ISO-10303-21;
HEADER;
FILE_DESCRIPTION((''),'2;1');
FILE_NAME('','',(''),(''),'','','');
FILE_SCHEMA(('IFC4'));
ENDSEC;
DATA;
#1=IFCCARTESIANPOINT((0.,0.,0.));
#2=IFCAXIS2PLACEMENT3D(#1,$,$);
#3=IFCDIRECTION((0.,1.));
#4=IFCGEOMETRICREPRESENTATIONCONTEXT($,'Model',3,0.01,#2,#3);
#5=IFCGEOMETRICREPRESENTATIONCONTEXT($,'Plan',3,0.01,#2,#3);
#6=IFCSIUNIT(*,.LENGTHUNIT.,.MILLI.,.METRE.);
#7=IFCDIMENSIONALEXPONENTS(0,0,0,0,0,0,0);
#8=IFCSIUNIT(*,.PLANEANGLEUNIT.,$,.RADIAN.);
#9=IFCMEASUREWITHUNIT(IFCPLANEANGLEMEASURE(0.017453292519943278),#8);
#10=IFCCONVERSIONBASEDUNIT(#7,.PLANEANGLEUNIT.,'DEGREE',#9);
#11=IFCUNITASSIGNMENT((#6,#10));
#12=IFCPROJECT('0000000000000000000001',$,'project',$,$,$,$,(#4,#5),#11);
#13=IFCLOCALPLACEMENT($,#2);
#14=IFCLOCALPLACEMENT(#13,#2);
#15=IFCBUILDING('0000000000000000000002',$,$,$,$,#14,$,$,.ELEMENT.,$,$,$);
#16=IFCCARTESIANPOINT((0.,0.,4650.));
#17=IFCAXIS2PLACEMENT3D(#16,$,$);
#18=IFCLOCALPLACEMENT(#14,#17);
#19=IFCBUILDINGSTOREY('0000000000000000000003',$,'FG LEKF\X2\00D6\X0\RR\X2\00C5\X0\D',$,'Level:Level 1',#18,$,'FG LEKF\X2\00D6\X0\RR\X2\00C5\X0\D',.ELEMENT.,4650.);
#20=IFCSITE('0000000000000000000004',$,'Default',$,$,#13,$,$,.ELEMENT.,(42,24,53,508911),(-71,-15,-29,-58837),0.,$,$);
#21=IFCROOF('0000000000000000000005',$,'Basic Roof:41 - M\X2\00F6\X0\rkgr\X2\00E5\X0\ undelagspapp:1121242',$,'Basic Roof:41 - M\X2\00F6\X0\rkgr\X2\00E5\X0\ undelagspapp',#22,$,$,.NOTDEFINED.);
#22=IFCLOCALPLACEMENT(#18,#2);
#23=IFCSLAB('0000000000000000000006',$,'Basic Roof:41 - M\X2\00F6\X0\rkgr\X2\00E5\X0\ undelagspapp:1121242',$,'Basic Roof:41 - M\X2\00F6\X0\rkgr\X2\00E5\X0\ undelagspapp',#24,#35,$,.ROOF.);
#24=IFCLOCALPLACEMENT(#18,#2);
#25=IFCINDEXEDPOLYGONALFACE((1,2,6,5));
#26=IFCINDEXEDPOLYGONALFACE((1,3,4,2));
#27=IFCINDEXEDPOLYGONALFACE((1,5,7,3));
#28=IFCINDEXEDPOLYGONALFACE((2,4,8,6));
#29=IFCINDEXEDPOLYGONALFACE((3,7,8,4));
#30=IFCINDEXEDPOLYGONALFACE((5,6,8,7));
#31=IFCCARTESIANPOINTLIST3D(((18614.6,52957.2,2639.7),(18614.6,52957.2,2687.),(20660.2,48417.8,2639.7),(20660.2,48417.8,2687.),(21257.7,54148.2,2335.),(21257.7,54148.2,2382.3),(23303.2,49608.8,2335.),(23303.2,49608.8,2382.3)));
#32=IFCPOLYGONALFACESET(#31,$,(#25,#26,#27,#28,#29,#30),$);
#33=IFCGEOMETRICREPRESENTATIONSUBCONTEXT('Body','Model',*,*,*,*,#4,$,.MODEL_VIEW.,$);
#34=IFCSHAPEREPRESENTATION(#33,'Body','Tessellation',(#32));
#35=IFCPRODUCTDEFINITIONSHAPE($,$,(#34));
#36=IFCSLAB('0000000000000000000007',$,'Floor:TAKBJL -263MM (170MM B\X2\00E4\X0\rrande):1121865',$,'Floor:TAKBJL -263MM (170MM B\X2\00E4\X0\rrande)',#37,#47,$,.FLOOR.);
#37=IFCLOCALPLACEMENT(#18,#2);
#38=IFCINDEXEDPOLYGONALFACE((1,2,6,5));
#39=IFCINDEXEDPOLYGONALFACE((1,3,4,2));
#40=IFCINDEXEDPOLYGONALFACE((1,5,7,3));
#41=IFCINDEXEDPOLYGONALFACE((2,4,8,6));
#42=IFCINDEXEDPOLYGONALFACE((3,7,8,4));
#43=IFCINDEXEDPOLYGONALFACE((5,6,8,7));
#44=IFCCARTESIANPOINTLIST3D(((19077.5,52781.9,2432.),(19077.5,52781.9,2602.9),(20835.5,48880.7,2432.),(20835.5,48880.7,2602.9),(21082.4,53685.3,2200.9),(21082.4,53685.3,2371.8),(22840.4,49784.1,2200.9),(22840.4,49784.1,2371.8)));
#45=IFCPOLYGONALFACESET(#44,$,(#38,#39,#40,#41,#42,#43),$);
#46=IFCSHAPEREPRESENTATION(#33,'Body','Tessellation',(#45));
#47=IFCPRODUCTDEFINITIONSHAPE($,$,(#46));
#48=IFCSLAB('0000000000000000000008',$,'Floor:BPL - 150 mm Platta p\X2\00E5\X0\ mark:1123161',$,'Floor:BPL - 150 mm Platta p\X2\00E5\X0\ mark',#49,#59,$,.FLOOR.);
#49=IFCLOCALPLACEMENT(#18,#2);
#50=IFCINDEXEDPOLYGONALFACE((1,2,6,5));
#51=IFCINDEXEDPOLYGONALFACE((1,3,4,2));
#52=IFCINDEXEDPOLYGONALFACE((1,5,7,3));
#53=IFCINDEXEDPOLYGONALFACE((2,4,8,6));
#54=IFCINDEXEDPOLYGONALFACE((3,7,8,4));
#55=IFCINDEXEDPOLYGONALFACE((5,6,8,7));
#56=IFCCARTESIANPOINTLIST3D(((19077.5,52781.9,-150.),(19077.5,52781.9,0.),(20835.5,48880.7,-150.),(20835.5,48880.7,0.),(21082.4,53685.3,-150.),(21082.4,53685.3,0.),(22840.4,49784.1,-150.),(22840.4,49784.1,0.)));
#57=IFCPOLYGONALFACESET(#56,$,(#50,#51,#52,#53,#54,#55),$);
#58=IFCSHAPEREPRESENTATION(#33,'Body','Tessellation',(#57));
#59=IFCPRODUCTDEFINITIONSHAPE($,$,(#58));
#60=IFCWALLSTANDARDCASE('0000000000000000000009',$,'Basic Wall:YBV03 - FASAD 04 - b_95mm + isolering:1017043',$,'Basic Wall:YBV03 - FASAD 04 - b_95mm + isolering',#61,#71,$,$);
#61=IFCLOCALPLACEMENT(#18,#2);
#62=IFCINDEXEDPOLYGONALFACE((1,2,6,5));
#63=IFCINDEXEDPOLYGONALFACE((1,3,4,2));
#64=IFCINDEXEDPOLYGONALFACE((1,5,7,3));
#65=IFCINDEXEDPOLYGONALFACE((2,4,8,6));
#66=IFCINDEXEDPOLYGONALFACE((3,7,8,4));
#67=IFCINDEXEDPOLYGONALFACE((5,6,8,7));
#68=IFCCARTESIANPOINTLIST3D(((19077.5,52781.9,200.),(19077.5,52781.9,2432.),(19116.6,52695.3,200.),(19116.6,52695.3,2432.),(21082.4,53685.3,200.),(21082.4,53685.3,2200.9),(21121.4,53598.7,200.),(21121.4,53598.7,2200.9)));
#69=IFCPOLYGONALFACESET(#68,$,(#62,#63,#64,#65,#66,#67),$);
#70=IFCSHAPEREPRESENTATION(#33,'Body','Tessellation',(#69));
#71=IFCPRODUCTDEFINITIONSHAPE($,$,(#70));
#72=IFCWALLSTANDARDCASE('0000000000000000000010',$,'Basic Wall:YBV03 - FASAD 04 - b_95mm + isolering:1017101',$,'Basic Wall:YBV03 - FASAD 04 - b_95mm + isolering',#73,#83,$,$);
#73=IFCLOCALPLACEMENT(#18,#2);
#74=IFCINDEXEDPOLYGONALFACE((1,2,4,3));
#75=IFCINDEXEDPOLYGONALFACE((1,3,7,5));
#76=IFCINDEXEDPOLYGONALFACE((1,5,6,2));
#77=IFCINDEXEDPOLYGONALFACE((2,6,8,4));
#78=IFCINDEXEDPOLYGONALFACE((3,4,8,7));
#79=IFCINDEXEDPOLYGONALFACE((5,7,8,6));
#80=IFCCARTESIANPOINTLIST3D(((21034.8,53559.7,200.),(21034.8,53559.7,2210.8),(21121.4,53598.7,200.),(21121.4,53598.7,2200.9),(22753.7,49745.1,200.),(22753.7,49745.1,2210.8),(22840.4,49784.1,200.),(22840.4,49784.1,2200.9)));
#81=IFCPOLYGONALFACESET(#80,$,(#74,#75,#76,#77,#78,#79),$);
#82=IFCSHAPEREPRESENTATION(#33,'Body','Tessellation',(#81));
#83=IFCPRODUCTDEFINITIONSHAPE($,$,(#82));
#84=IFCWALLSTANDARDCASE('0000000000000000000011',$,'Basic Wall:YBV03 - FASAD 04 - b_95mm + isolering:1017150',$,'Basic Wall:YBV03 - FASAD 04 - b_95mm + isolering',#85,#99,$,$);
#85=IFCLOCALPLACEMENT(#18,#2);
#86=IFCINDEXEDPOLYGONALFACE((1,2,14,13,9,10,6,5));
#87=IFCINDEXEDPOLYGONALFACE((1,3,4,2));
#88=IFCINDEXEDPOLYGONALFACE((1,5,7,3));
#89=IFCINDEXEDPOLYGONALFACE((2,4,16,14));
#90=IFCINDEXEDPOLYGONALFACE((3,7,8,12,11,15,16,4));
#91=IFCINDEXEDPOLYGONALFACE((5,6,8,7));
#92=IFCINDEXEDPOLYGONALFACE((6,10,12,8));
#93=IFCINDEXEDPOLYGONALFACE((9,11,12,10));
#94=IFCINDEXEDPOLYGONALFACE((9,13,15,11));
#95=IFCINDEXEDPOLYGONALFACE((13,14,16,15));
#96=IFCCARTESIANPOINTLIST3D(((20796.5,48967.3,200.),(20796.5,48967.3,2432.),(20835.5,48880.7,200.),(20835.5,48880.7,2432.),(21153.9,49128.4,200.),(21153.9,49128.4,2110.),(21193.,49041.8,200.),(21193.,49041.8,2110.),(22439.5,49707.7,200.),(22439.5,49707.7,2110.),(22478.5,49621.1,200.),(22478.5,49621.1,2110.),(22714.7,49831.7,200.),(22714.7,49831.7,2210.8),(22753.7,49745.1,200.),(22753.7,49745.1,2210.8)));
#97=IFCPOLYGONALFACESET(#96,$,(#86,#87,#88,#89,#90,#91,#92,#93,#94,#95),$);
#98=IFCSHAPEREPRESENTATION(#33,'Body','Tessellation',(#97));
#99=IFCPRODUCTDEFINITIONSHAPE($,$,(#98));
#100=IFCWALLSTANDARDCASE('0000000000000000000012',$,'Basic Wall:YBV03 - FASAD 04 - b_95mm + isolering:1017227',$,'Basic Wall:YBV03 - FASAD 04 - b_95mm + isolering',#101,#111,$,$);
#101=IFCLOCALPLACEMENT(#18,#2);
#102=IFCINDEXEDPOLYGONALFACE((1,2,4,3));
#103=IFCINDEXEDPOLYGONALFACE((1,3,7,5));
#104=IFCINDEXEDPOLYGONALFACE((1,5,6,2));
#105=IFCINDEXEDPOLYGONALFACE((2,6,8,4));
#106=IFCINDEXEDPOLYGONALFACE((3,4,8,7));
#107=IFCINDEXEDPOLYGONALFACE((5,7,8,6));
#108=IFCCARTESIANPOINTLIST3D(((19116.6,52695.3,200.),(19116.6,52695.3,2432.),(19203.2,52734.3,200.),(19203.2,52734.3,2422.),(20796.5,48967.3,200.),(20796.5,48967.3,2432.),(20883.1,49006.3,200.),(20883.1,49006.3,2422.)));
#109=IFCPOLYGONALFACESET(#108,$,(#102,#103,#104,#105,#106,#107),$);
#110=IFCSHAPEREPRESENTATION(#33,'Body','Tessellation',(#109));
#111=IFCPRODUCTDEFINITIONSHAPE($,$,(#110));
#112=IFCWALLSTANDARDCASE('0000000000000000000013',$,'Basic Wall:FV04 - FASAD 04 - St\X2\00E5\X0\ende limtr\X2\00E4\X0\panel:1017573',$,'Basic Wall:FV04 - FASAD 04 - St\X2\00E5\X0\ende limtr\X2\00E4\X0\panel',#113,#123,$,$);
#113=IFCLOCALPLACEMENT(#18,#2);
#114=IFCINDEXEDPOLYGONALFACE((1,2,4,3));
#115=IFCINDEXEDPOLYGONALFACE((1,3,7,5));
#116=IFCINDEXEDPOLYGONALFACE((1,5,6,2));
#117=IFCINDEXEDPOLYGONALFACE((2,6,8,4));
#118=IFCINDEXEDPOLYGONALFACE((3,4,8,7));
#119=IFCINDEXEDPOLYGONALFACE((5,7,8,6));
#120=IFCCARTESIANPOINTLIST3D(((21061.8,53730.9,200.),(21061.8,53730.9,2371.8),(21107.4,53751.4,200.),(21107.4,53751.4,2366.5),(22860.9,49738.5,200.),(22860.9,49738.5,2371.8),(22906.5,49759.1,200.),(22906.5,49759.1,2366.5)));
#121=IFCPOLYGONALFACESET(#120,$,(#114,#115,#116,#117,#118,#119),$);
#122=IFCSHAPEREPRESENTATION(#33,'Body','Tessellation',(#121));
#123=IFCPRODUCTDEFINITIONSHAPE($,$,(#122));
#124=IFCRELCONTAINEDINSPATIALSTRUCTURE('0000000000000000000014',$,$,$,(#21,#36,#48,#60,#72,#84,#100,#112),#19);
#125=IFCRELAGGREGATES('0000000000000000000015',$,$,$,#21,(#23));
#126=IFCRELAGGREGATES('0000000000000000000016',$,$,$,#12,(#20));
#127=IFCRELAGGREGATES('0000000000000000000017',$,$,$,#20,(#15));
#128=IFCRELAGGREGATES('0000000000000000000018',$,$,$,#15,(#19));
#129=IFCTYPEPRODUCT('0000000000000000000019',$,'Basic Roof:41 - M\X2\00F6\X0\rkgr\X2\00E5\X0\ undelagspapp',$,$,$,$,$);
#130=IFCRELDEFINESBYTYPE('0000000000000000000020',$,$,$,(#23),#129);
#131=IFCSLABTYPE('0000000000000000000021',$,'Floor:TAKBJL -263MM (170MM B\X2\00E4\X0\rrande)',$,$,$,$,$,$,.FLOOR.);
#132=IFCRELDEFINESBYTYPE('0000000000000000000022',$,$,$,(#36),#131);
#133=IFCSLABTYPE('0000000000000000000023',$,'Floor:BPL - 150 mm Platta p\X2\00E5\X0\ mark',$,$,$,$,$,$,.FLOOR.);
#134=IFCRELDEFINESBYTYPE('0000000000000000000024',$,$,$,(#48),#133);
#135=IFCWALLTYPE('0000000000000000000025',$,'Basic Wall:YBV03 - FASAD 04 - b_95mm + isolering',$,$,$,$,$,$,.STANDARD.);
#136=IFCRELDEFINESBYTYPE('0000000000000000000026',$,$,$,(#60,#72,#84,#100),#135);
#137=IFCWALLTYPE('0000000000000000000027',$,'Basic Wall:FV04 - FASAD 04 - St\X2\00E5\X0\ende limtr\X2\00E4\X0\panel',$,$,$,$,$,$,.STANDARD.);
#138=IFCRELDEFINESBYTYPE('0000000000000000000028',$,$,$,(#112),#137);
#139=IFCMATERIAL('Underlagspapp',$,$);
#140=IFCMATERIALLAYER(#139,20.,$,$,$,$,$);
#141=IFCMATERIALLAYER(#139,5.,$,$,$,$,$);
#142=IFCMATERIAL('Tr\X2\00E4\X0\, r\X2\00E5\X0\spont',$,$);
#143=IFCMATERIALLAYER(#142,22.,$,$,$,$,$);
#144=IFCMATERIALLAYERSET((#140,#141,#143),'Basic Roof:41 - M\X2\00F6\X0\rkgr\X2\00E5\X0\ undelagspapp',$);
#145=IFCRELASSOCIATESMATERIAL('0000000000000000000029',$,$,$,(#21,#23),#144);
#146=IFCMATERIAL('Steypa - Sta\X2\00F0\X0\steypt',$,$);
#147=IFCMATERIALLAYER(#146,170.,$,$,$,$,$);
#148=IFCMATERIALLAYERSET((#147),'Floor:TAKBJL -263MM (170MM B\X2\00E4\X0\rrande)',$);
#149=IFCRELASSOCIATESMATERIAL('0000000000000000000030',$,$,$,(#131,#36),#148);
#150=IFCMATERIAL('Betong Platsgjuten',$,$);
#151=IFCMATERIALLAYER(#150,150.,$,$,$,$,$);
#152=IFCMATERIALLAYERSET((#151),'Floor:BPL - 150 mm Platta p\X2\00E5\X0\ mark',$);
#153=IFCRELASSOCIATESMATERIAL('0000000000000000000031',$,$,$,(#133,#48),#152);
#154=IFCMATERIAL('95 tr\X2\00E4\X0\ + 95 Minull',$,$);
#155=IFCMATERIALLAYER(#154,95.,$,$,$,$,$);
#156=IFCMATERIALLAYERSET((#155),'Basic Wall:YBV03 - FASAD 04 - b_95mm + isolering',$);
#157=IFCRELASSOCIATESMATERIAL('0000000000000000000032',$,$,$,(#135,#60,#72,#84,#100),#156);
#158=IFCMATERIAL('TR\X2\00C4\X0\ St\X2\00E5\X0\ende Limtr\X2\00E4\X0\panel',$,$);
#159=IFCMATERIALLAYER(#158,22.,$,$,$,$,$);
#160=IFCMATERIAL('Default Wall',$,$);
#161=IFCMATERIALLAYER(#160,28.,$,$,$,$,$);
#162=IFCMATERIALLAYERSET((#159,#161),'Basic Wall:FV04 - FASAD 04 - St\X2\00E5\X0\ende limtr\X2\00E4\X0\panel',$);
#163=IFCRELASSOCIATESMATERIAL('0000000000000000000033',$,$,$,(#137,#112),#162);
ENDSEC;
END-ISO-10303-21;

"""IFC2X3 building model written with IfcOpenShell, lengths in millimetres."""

from ifc_helpers import new_model, entity, si_unit, converted_unit, direction, frame, frame_2d, origin, place, context, subcontext, project, spatial, polyline, rectangle, extrude, clip, halfspace, bounded_halfspace, material, layer, layer_set, layer_usage, type_object, element, aggregate, save


model = new_model("IFC2X3")

# Units and contexts
model_context = context("Model", 3, precision=0.01, world=origin(), true_north=direction((0.0, 1.0)))
plan_context = context("Plan", 3, precision=0.01, world=origin(), true_north=direction((0.0, 1.0)))
body_context = subcontext(model_context, "Body", "Model", "MODEL_VIEW")
ifc_project = project(units=[si_unit("LENGTHUNIT", "METRE", prefix="MILLI"), converted_unit("PLANEANGLEUNIT", "DEGREE", entity("IfcPlaneAngleMeasure", 0.017453292519943278), si_unit("PLANEANGLEUNIT", "RADIAN"), dimensions=[0, 0, 0, 0, 0, 0, 0])], contexts=[model_context, plan_context])

# Site, building, storey
site_placement = place(None, origin())
site = spatial("IfcSite", under=ifc_project, at=site_placement, Name="Default", CompositionType="ELEMENT", RefLatitude=(42, 24, 53, 508911), RefLongitude=(-71, -15, -29, -58837), RefElevation=0.0)
building_placement = place(site_placement, origin())
building = spatial("IfcBuilding", under=site, at=building_placement, CompositionType="ELEMENT")
storey_placement = place(building_placement, frame((0.0, 0.0, 4650.0)))
storey = spatial("IfcBuildingStorey", under=building, at=storey_placement, Name="FG LEKFÖRRÅD", ObjectType="Level:Level 1", LongName="FG LEKFÖRRÅD", CompositionType="ELEMENT", Elevation=4650.0)

# Roof, slab
ifc_material_1 = material(Name="Underlagspapp")
ifc_layer_1 = layer(ifc_material_1, 20.0)
ifc_layer_2 = layer(ifc_material_1, 5.0)
ifc_material_2 = material(Name="Trä, råspont")
ifc_layer_3 = layer(ifc_material_2, 22.0)
ifc_layer_set_1 = layer_set([ifc_layer_1, ifc_layer_2, ifc_layer_3], Name="Basic Roof:41 - Mörkgrå undelagspapp")
roof_placement = place(storey_placement, frame((18614.6, 48417.8, 2335.0)))
roof = element("IfcRoof", 1, at=roof_placement, inside=storey, material=ifc_layer_set_1, Name="Basic Roof:41 - Mörkgrå undelagspapp:1121242", ObjectType="Basic Roof:41 - Mörkgrå undelagspapp", ShapeType="NOTDEFINED")
type_product = type_object("IfcTypeProduct", Name="Basic Roof:41 - Mörkgrå undelagspapp")
slab_1_placement = place(roof_placement, origin())
slab_1 = element("IfcSlab", 2, at=slab_1_placement, type_object=type_product, material=ifc_layer_set_1, Name="Basic Roof:41 - Mörkgrå undelagspapp:1121242", ObjectType="Basic Roof:41 - Mörkgrå undelagspapp", PredefinedType="ROOF", context=body_context, shape_type="SweptSolid", body=[
    extrude(rectangle(XDim=2915.0, YDim=4979.0, at=frame_2d((0.0, 0.0), x_axis=(-0.910861, -0.412714))), frame((2344.3, 2865.2, 152.3), z_axis=(0.0953, 0.042944, 0.994522), x_axis=(0.995449, -0.004111, -0.095211)), (-0.095211, -0.04314, 0.994522), 47.3),
])
aggregate(roof, [slab_1])

# Slabs
ifc_material_3 = material(Name="Steypa - Staðsteypt")
ifc_layer_4 = layer(ifc_material_3, 170.0)
ifc_layer_set_2 = layer_set([ifc_layer_4], Name="Floor:TAKBJL -263MM (170MM Bärrande)")
ifc_layer_usage_1 = layer_usage(ifc_layer_set_2, "AXIS3", "POSITIVE", 0.0)
slab_type_1 = type_object("IfcSlabType", Name="Floor:TAKBJL -263MM (170MM Bärrande)", PredefinedType="FLOOR", material=ifc_layer_set_2)
slab_2_placement = place(storey_placement, origin())
element("IfcSlab", 3, at=slab_2_placement, inside=storey, type_object=slab_type_1, material=ifc_layer_usage_1, Name="Floor:TAKBJL -263MM (170MM Bärrande):1121865", ObjectType="Floor:TAKBJL -263MM (170MM Bärrande)", PredefinedType="FLOOR", context=body_context, shape_type="SweptSolid", body=[
    clip(clip(extrude(rectangle(XDim=2211.1, YDim=4279.0, at=frame_2d((0.0, 0.0), x_axis=(0.0, 1.0))), frame((20958.9, 51283.0, 2487.3), z_axis=(-0.0953, -0.042944, -0.994522), x_axis=(0.410836, -0.911709, 0.0)), (0.0, -0.104528, 0.994522), 171.9), halfspace(frame((21863.4, 51952.2, 2200.9), z_axis=(-0.0953, -0.042944, -0.994522), x_axis=(-0.906715, -0.408585, 0.104528)), False)), halfspace(frame((21863.4, 51952.2, 2371.8), z_axis=(0.0953, 0.042944, 0.994522), x_axis=(0.906715, 0.408585, -0.104528)), False)),
])
ifc_material_4 = material(Name="Betong Platsgjuten")
ifc_layer_5 = layer(ifc_material_4, 150.0)
ifc_layer_set_3 = layer_set([ifc_layer_5], Name="Floor:BPL - 150 mm Platta på mark")
ifc_layer_usage_2 = layer_usage(ifc_layer_set_3, "AXIS3", "POSITIVE", 0.0)
slab_type_2 = type_object("IfcSlabType", Name="Floor:BPL - 150 mm Platta på mark", PredefinedType="FLOOR", material=ifc_layer_set_3)
slab_3_placement = place(storey_placement, origin())
element("IfcSlab", 4, at=slab_3_placement, inside=storey, type_object=slab_type_2, material=ifc_layer_usage_2, Name="Floor:BPL - 150 mm Platta på mark:1123161", ObjectType="Floor:BPL - 150 mm Platta på mark", PredefinedType="FLOOR", context=body_context, shape_type="SweptSolid", body=[
    extrude(rectangle(XDim=4279.0, YDim=2199.0, at=frame_2d((0.0, 0.0), x_axis=(1.0, 0.0))), frame((20958.9, 51283.0, 0.0), z_axis=(0.0, 0.0, -1.0), x_axis=(0.410836, -0.911709, 0.0)), (0.0, 0.0, 1.0), 150.0),
])

# Walls
ifc_material_5 = material(Name="95 trä + 95 Minull")
ifc_layer_6 = layer(ifc_material_5, 95.0)
ifc_layer_set_4 = layer_set([ifc_layer_6], Name="Basic Wall:YBV03 - FASAD 04 - b_95mm + isolering")
ifc_layer_usage_3 = layer_usage(ifc_layer_set_4, "AXIS2", "NEGATIVE", 47.5)
wall_type_1 = type_object("IfcWallType", Name="Basic Wall:YBV03 - FASAD 04 - b_95mm + isolering", PredefinedType="STANDARD", material=ifc_layer_set_4)
wall_1_placement = place(storey_placement, frame((19097.1, 52738.6, 200.0), z_axis=(0.0, 0.0, 1.0), x_axis=(0.911709, 0.410836, 0.0)))
element("IfcWallStandardCase", 5, at=wall_1_placement, inside=storey, type_object=wall_type_1, material=ifc_layer_usage_3, Name="Basic Wall:YBV03 - FASAD 04 - b_95mm + isolering:1017043", ObjectType="Basic Wall:YBV03 - FASAD 04 - b_95mm + isolering", context=body_context, shape_type="Clipping", body=[
    clip(extrude(rectangle(XDim=2199.0, YDim=95.0, at=frame_2d((1099.5, 0.0), x_axis=(-1.0, 0.0))), origin(), (0.0, 0.0, 1.0), 2232.0), bounded_halfspace(frame((0.0, -47.5, 2232.0), z_axis=(-0.104528, 0.0, -0.994522), x_axis=(-0.994522, 0.0, 0.104528)), True, frame((0.0, -47.5, 2232.0)), polyline([(0.0, 0.0), (95.0, 0.0), (107.0, 0.0), (2092.0, 0.0), (2104.0, 0.0), (2199.0, 0.0), (2199.0, 95.0), (0.0, 95.0), (0.0, 0.0)]))),
])
ifc_layer_usage_4 = layer_usage(ifc_layer_set_4, "AXIS2", "NEGATIVE", 47.5)
wall_2_placement = place(storey_placement, frame((21078.1, 53579.2, 200.0), z_axis=(0.0, 0.0, 1.0), x_axis=(0.410836, -0.911709, 0.0)))
element("IfcWallStandardCase", 6, at=wall_2_placement, inside=storey, type_object=wall_type_1, material=ifc_layer_usage_4, Name="Basic Wall:YBV03 - FASAD 04 - b_95mm + isolering:1017101", ObjectType="Basic Wall:YBV03 - FASAD 04 - b_95mm + isolering", context=body_context, shape_type="Clipping", body=[
    clip(extrude(rectangle(XDim=4184.0, YDim=95.0, at=frame_2d((2092.0, 0.0), x_axis=(-1.0, 0.0))), origin(), (0.0, 0.0, 1.0), 2010.8), bounded_halfspace(frame((0.0, -47.5, 2010.8), z_axis=(0.0, -0.104528, -0.994522), x_axis=(0.0, -0.994522, 0.104528)), True, frame((0.0, -47.5, 2010.8)), polyline([(0.0, 0.0), (12.0, 0.0), (4077.0, 0.0), (4089.0, 0.0), (4184.0, 0.0), (4184.0, 95.0), (0.0, 95.0), (0.0, 0.0)]))),
])

# Wall, opening
ifc_layer_usage_5 = layer_usage(ifc_layer_set_4, "AXIS2", "NEGATIVE", 47.5)
wall_3_placement = place(storey_placement, frame((22734.2, 49788.4, 200.0), z_axis=(0.0, 0.0, 1.0), x_axis=(-0.911709, -0.410836, 0.0)))
wall_3 = element("IfcWallStandardCase", 7, at=wall_3_placement, inside=storey, type_object=wall_type_1, material=ifc_layer_usage_5, Name="Basic Wall:YBV03 - FASAD 04 - b_95mm + isolering:1017150", ObjectType="Basic Wall:YBV03 - FASAD 04 - b_95mm + isolering", context=body_context, shape_type="Clipping", body=[
    clip(extrude(rectangle(XDim=2104.0, YDim=95.0, at=frame_2d((1052.0, 0.0), x_axis=(1.0, 0.0))), origin(), (0.0, 0.0, 1.0), 2232.0), bounded_halfspace(frame((0.0, -47.5, 2010.8), z_axis=(0.104528, 0.0, -0.994522), x_axis=(0.994522, 0.0, 0.104528)), True, frame((0.0, -47.5, 2010.8)), polyline([(0.0, 0.0), (12.0, 0.0), (1997.0, 0.0), (2009.0, 0.0), (2104.0, 0.0), (2104.0, 95.0), (0.0, 95.0), (0.0, 0.0)]))),
])
opening_1_placement = place(wall_3_placement, origin())
element("IfcOpeningElement", 8, at=opening_1_placement, cuts=wall_3, ObjectType="Opening", context=body_context, shape_type="SweptSolid", body=[
    extrude(rectangle(XDim=2110.0, YDim=1410.0, at=frame_2d((0.0, 0.0), x_axis=(1.0, 0.0))), frame((1006.9, -1476.5, 855.0), z_axis=(0.0, 1.0, 0.0), x_axis=(0.0, 0.0, 1.0)), (0.0, 0.0, 1.0), 3048.0),
])

# Walls
ifc_layer_usage_6 = layer_usage(ifc_layer_set_4, "AXIS2", "NEGATIVE", 47.5)
wall_4_placement = place(storey_placement, frame((20839.8, 48986.8, 200.0), z_axis=(0.0, 0.0, 1.0), x_axis=(-0.410836, 0.911709, 0.0)))
element("IfcWallStandardCase", 9, at=wall_4_placement, inside=storey, type_object=wall_type_1, material=ifc_layer_usage_6, Name="Basic Wall:YBV03 - FASAD 04 - b_95mm + isolering:1017227", ObjectType="Basic Wall:YBV03 - FASAD 04 - b_95mm + isolering", context=body_context, shape_type="Clipping", body=[
    clip(extrude(rectangle(XDim=4089.0, YDim=95.0, at=frame_2d((2044.5, 0.0), x_axis=(-1.0, 0.0))), origin(), (0.0, 0.0, 1.0), 2232.0), bounded_halfspace(frame((0.0, -47.5, 2222.0), z_axis=(0.0, 0.104528, -0.994522), x_axis=(0.0, 0.994522, 0.104528)), True, frame((0.0, -47.5, 2222.0)), polyline([(0.0, 0.0), (12.0, 0.0), (4077.0, 0.0), (4089.0, 0.0), (4089.0, 95.0), (0.0, 95.0), (0.0, 0.0)]))),
])
ifc_material_6 = material(Name="TRÄ Stående Limträpanel")
ifc_layer_7 = layer(ifc_material_6, 22.0)
ifc_material_7 = material(Name="Default Wall")
ifc_layer_8 = layer(ifc_material_7, 28.0)
ifc_layer_set_5 = layer_set([ifc_layer_7, ifc_layer_8], Name="Basic Wall:FV04 - FASAD 04 - Stående limträpanel")
ifc_layer_usage_7 = layer_usage(ifc_layer_set_5, "AXIS2", "NEGATIVE", 25.0)
wall_type_2 = type_object("IfcWallType", Name="Basic Wall:FV04 - FASAD 04 - Stående limträpanel", PredefinedType="STANDARD", material=ifc_layer_set_5)
wall_5_placement = place(storey_placement, frame((21084.6, 53741.2, 200.0), z_axis=(0.0, 0.0, 1.0), x_axis=(0.410836, -0.911709, 0.0)))
element("IfcWallStandardCase", 10, at=wall_5_placement, inside=storey, type_object=wall_type_2, material=ifc_layer_usage_7, Name="Basic Wall:FV04 - FASAD 04 - Stående limträpanel:1017573", ObjectType="Basic Wall:FV04 - FASAD 04 - Stående limträpanel", context=body_context, shape_type="Clipping", body=[
    clip(extrude(rectangle(XDim=4379.0, YDim=50.0, at=frame_2d((2189.5, 0.0), x_axis=(-1.0, 0.0))), origin(), (0.0, 0.0, 1.0), 2171.8), bounded_halfspace(frame((0.0, -25.0, 2171.8), z_axis=(0.0, 0.104528, 0.994522), x_axis=(-1.0, 0.0, 0.0)), False, frame((0.0, -25.0, 2171.8)), polyline([(0.0, 0.0), (50.0, 0.0), (4329.0, 0.0), (4379.0, 0.0), (4379.0, 50.0), (0.0, 50.0), (0.0, 0.0)]))),
])

save(model, "model.ifc")
